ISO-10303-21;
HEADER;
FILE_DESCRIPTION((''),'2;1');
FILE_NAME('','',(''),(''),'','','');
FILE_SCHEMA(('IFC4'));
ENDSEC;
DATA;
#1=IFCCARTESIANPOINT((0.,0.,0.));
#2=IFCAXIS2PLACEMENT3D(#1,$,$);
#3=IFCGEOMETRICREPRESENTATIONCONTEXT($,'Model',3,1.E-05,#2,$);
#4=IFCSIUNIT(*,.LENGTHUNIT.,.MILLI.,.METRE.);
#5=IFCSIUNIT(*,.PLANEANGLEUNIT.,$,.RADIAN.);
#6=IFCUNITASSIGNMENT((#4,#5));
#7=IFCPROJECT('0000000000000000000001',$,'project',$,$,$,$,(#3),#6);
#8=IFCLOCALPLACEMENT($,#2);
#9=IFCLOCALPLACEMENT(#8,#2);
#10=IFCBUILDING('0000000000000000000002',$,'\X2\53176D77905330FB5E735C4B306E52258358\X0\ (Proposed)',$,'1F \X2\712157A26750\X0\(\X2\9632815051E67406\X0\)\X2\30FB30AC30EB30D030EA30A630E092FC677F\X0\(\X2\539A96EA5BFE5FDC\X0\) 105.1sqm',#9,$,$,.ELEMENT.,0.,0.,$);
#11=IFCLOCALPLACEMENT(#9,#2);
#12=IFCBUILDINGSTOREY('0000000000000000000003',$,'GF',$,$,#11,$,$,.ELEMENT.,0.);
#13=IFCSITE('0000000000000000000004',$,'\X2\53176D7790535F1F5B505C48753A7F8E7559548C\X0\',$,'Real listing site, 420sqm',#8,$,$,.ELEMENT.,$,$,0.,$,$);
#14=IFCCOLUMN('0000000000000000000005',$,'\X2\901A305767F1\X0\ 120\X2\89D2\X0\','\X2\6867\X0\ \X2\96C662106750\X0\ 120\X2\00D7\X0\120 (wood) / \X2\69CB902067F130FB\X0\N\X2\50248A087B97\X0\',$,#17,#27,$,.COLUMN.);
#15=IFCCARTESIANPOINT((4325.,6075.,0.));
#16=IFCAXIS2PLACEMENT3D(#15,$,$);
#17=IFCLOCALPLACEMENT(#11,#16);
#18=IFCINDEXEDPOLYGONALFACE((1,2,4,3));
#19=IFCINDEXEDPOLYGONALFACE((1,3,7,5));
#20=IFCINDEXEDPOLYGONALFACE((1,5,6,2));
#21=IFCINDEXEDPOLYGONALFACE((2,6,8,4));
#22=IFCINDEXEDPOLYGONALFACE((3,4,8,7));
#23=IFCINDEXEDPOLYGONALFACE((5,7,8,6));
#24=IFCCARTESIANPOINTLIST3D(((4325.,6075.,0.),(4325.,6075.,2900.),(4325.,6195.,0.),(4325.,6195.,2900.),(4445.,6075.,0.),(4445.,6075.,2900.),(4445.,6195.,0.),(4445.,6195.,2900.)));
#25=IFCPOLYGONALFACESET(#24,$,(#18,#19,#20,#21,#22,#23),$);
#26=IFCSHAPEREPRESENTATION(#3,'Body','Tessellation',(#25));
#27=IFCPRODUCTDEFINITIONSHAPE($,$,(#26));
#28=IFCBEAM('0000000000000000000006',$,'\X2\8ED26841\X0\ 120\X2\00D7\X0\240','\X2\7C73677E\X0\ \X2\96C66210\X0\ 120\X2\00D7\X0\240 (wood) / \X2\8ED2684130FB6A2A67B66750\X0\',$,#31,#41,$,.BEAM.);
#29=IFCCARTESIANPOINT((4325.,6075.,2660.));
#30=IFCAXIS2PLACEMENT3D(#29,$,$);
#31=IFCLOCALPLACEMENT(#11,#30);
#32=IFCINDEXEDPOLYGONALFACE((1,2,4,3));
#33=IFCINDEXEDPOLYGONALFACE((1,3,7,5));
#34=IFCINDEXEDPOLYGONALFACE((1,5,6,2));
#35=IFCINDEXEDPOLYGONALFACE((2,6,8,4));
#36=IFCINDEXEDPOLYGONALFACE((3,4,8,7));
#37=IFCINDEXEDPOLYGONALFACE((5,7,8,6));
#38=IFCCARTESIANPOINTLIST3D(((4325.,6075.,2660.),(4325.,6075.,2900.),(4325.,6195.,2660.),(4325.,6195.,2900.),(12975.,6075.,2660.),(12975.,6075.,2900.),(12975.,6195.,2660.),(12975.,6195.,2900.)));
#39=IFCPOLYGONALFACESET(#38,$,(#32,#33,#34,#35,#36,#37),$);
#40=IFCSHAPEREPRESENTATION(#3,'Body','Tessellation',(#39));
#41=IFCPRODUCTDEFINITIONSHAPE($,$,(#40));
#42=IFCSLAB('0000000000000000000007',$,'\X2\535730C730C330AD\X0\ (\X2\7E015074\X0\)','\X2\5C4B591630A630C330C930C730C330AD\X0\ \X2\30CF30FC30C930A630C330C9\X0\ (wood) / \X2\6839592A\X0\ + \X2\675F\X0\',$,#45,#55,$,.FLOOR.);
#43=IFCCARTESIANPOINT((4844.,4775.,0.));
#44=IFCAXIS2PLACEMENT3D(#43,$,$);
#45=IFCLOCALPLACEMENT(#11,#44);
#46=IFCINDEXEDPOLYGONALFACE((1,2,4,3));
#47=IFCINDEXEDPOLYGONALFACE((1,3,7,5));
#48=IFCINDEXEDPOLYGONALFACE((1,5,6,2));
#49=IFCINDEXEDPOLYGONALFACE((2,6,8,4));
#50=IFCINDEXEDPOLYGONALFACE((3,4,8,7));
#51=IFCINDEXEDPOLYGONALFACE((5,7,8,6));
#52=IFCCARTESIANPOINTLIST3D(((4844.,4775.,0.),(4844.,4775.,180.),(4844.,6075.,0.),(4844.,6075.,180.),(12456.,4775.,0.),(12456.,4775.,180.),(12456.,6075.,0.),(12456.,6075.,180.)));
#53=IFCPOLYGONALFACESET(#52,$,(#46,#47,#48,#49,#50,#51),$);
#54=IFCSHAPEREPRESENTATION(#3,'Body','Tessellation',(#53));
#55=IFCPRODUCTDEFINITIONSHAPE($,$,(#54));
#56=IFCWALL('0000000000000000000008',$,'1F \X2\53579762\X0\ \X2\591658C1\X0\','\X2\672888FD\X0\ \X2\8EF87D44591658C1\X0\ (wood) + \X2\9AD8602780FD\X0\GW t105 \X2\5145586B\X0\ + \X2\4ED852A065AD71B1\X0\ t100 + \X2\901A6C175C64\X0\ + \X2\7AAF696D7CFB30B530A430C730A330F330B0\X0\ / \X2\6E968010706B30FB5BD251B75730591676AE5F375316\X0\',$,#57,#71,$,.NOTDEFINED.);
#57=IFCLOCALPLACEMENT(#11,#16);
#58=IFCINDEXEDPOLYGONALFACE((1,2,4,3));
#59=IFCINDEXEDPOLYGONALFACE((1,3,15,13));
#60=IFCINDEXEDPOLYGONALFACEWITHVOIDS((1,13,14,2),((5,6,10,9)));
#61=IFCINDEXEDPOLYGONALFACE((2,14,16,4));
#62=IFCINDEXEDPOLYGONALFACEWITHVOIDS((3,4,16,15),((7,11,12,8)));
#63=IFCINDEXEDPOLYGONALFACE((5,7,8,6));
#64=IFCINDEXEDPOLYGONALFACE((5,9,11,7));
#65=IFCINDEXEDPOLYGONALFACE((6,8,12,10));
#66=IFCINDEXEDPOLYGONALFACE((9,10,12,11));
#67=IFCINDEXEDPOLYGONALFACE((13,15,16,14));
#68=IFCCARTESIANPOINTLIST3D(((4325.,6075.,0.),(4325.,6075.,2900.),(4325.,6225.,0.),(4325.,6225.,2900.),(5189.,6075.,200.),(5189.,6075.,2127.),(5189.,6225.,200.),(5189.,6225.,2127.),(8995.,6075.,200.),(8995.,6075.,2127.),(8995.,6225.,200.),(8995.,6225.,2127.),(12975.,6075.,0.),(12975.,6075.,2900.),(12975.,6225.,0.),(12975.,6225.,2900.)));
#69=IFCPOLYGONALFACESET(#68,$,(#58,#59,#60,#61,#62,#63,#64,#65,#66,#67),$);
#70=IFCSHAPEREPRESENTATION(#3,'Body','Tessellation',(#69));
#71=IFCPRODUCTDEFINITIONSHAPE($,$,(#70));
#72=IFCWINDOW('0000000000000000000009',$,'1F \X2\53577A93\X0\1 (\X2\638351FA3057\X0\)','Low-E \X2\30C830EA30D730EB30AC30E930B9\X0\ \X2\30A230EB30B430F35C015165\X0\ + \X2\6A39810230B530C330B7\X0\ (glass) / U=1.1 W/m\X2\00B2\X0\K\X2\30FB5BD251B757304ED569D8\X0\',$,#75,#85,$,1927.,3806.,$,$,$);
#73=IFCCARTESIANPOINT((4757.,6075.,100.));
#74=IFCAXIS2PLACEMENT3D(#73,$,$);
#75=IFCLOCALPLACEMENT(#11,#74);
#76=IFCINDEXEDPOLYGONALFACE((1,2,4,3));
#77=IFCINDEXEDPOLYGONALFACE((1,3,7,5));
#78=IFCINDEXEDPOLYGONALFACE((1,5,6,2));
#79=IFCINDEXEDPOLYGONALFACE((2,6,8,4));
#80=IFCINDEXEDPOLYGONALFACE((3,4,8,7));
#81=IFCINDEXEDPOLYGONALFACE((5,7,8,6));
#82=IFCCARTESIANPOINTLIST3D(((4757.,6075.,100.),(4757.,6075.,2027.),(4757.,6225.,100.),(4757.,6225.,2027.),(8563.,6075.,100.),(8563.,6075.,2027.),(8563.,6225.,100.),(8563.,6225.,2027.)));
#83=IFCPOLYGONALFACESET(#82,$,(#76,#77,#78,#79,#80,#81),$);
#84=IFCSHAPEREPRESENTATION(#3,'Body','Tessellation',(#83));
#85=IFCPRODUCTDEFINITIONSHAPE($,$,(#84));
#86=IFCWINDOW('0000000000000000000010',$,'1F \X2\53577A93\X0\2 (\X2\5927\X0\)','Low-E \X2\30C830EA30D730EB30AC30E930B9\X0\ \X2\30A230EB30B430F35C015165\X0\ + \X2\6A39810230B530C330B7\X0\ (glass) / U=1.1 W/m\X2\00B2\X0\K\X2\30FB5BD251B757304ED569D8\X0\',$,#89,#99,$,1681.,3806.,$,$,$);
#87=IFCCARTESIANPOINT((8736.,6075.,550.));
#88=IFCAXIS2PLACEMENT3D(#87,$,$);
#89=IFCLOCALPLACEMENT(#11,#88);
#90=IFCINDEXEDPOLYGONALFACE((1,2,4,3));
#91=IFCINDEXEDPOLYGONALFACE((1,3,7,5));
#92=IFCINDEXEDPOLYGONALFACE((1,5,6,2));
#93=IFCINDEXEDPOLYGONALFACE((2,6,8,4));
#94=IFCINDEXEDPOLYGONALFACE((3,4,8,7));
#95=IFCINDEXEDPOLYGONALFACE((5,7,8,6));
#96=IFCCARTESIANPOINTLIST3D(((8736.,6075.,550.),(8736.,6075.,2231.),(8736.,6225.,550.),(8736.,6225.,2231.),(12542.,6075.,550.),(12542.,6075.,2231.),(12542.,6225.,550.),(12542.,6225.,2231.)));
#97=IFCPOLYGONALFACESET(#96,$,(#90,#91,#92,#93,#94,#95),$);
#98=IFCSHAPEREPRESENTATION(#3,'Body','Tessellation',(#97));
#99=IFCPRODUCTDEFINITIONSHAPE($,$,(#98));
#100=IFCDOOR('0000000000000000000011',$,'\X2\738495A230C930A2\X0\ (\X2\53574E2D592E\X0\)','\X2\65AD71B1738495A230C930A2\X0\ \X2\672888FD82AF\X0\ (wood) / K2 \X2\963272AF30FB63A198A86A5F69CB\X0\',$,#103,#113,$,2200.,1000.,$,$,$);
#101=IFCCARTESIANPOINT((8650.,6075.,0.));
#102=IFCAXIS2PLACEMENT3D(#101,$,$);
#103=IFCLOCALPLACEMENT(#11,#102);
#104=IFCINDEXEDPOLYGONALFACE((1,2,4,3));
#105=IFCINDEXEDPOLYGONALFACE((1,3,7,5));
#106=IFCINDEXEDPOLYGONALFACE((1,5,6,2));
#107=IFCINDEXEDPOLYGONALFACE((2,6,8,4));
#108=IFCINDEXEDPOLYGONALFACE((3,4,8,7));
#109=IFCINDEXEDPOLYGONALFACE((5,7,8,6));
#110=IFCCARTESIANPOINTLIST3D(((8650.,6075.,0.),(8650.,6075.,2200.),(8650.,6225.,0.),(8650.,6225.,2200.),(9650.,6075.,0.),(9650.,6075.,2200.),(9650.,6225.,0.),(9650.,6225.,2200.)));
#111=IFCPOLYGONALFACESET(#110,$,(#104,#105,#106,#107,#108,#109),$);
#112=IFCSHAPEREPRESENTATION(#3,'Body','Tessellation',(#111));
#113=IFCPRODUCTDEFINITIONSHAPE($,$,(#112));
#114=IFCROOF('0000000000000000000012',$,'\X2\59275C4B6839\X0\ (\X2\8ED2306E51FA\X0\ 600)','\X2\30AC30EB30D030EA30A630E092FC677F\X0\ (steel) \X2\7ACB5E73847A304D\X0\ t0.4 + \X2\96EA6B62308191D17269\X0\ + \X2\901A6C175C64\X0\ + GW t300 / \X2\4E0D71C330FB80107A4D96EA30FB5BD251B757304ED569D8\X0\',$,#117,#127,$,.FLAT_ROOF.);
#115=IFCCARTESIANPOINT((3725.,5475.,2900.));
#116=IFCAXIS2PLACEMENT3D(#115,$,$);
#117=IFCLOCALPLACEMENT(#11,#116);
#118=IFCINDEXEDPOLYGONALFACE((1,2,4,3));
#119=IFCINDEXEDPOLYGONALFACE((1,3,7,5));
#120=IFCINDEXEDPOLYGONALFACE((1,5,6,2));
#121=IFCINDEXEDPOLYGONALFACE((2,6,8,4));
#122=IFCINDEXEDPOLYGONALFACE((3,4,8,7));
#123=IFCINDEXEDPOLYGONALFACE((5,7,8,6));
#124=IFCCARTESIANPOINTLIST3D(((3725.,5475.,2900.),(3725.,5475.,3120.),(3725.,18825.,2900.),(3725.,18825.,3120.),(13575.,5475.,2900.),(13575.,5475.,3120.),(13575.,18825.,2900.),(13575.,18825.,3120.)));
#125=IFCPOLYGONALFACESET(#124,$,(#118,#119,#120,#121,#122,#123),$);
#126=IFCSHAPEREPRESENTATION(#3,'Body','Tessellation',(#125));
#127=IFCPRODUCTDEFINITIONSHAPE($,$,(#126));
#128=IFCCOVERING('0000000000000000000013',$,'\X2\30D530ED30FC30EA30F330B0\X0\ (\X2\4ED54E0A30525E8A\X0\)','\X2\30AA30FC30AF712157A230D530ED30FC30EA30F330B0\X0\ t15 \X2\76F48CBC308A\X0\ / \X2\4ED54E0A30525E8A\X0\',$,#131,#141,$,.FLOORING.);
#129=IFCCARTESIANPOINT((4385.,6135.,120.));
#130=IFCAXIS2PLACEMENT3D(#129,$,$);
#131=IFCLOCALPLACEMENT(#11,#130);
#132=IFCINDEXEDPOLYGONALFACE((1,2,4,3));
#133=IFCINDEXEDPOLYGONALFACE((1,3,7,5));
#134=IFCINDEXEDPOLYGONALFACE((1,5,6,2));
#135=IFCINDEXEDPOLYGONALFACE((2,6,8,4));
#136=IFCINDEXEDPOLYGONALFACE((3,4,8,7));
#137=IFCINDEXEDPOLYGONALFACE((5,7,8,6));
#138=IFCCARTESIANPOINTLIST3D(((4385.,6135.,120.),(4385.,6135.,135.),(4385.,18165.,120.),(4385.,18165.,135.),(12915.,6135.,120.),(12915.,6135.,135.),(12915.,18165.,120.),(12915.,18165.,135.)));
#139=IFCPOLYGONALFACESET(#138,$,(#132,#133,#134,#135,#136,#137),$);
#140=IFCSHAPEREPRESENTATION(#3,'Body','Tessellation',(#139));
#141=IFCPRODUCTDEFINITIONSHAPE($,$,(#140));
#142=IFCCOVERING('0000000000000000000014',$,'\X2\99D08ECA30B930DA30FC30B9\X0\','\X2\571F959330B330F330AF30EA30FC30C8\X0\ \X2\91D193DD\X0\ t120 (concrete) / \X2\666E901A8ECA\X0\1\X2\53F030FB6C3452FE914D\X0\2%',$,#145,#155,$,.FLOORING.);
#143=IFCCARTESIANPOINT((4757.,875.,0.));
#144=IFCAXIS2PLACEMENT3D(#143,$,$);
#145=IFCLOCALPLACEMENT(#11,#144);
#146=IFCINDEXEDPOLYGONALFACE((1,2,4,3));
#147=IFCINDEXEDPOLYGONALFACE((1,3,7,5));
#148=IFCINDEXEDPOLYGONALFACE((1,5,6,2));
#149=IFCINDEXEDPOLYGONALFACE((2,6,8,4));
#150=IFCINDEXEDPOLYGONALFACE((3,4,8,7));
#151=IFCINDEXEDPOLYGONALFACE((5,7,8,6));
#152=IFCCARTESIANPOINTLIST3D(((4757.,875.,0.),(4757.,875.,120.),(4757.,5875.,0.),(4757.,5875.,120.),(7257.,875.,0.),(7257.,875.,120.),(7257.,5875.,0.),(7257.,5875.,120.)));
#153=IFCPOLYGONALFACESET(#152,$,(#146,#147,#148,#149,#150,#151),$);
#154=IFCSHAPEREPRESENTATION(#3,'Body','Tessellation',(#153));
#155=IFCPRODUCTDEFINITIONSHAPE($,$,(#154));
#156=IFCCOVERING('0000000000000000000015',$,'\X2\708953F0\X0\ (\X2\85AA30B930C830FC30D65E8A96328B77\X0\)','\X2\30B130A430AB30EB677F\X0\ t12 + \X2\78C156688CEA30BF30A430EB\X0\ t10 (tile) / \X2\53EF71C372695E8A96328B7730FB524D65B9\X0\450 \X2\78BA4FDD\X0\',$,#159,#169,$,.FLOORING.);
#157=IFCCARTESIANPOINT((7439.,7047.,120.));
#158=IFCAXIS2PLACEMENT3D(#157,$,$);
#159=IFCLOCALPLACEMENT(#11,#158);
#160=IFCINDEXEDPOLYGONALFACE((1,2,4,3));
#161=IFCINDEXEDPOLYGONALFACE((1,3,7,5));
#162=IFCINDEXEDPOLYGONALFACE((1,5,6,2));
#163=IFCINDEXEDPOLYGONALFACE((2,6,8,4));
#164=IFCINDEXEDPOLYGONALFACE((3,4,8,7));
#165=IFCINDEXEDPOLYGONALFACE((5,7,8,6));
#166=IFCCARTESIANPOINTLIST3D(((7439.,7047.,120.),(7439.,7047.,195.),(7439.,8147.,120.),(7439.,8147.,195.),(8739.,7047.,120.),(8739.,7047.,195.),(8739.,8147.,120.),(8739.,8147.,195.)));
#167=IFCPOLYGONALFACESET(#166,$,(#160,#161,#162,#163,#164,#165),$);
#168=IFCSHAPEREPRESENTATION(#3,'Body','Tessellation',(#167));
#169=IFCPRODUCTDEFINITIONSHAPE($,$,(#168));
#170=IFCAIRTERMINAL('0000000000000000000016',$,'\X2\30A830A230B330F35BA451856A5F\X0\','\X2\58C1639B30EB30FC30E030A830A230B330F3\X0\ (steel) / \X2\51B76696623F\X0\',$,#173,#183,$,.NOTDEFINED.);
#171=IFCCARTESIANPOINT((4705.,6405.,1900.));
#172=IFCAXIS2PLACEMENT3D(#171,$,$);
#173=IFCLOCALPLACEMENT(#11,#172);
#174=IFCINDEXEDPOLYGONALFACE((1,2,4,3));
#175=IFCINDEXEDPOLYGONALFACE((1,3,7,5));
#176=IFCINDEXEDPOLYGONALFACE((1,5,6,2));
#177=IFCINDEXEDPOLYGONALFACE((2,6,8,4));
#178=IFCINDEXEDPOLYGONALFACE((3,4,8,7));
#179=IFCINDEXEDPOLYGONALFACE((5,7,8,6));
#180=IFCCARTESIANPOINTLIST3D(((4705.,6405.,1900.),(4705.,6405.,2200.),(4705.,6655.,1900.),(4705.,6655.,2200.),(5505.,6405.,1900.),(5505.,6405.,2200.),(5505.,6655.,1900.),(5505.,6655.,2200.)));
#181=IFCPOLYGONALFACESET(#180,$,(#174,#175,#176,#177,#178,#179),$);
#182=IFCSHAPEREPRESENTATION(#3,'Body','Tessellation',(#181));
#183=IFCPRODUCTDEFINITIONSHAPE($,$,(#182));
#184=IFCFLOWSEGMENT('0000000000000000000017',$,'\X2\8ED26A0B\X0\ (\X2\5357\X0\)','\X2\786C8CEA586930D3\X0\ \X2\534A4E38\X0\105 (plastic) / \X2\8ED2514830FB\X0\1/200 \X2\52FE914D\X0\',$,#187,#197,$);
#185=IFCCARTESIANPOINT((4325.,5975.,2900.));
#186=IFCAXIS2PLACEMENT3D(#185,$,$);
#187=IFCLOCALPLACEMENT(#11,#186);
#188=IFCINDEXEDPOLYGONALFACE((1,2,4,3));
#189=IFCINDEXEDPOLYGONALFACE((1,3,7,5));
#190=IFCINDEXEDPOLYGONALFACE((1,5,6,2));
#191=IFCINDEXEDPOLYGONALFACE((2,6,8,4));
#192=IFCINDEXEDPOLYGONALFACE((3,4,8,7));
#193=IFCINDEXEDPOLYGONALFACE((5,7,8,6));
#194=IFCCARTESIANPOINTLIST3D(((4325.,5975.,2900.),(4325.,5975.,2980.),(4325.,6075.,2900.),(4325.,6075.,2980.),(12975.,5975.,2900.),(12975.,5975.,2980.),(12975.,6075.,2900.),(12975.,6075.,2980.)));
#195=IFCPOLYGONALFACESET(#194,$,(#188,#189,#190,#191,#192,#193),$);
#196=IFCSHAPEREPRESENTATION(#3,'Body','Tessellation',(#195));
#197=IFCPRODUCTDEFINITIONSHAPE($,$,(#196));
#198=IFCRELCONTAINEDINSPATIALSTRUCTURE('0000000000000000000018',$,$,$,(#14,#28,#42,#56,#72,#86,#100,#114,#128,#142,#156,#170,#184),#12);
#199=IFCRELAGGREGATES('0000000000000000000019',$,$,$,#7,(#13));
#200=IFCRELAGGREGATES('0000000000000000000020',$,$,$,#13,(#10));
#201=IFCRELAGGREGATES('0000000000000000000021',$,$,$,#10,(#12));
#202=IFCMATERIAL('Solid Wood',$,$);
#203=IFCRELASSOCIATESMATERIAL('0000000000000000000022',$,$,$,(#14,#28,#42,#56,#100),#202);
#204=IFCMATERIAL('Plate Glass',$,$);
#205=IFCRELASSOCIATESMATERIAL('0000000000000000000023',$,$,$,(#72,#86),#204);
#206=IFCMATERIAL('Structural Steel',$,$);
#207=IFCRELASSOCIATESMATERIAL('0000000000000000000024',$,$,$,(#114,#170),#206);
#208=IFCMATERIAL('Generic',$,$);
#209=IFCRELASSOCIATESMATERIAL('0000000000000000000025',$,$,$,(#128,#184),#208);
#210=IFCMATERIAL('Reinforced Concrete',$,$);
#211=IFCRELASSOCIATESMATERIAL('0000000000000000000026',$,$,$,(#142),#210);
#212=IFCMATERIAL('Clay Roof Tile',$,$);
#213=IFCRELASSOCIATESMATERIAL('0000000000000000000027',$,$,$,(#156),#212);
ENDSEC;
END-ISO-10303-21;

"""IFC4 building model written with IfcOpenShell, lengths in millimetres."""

from ifc_helpers import new_model, si_unit, frame, frame_2d, origin, place, context, project, spatial, rectangle, extrude, material, element, fill, save


model = new_model("IFC4")

# Units and contexts
model_context = context("Model", 3, precision=1e-05, world=origin())
ifc_project = project(units=[si_unit("LENGTHUNIT", "METRE", prefix="MILLI"), si_unit("PLANEANGLEUNIT", "RADIAN")], contexts=[model_context])

# Site, building, storey
site_placement = place(None, origin())
site = spatial("IfcSite", under=ifc_project, at=site_placement, Name="北海道弟子屈町美留和", ObjectType="Real listing site, 420sqm", CompositionType="ELEMENT", RefElevation=0.0)
building_placement = place(site_placement, origin())
building = spatial("IfcBuilding", under=site, at=building_placement, Name="北海道・平屋の別荘 (Proposed)", ObjectType="1F 無垢材(防腐処理)・ガルバリウム鋼板(厚雪対応) 105.1sqm", CompositionType="ELEMENT", ElevationOfRefHeight=0.0, ElevationOfTerrain=0.0)
storey_placement = place(building_placement, origin())
storey = spatial("IfcBuildingStorey", under=building, at=storey_placement, Name="GF", CompositionType="ELEMENT", Elevation=0.0)

# Column
ifc_material_1 = material(Name="Solid Wood")
column_1_placement = place(storey_placement, frame((4325.0, 6075.0, 0.0)))
element("IfcColumn", 1, at=column_1_placement, inside=storey, material=ifc_material_1, Name="通し柱 120角", Description="桧 集成材 120×120 (wood) / 構造柱・N値計算", PredefinedType="COLUMN", context=model_context, shape_type="SweptSolid", body=[
    extrude(rectangle(XDim=120.0, YDim=120.0, at=frame_2d((60.0, 60.0))), frame((4325.0, 6075.0, 0.0)), (0.0, 0.0, 1.0), 2900.0),
])

# Beam
beam_1_placement = place(storey_placement, frame((4325.0, 6075.0, 2660.0)))
element("IfcBeam", 2, at=beam_1_placement, inside=storey, material=ifc_material_1, Name="軒桁 120×240", Description="米松 集成 120×240 (wood) / 軒桁・横架材", PredefinedType="BEAM", context=model_context, shape_type="SweptSolid", body=[
    extrude(rectangle(XDim=8650.0, YDim=120.0, at=frame_2d((4325.0, 60.0))), frame((4325.0, 6075.0, 2660.0)), (0.0, 0.0, 1.0), 240.0),
])

# Slab
ifc_material_2 = material(Name="Reinforced Concrete")
slab_1_placement = place(storey_placement, frame((4844.0, 4775.0, 0.0)))
element("IfcSlab", 3, at=slab_1_placement, inside=storey, material=ifc_material_1, Name="南デッキ (縁側)", Description="屋外ウッドデッキ ハードウッド (wood) / 根太 + 束", PredefinedType="FLOOR", context=model_context, shape_type="SweptSolid", body=[
    extrude(rectangle(XDim=7612.0, YDim=1300.0, at=frame_2d((3806.0, 650.0))), frame((4844.0, 4775.0, 0.0)), (0.0, 0.0, 1.0), 180.0),
])

# Wall, openings, windows, door
wall_1_placement = place(storey_placement, frame((4325.0, 6075.0, 0.0)))
wall_1 = element("IfcWall", 4, at=wall_1_placement, inside=storey, material=ifc_material_1, Name="1F 南面 外壁", Description="木製 軸組外壁 (wood) + 高性能GW t105 充填 + 付加断熱 t100 + 通気層 + 窯業系サイディング / 準耐火・寒冷地外皮強化", PredefinedType="NOTDEFINED", context=model_context, shape_type="SweptSolid", body=[
    extrude(rectangle(XDim=8650.0, YDim=150.0, at=frame_2d((4325.0, 75.0))), frame((4325.0, 6075.0, 0.0)), (0.0, 0.0, 1.0), 2900.0),
])
opening_1_placement = place(storey_placement, frame((4757.0, 6075.0, 100.0)))
opening_1 = element("IfcOpeningElement", 5, at=opening_1_placement, cuts=wall_1, PredefinedType="NOTDEFINED", context=model_context, shape_type="SweptSolid", body=[
    extrude(rectangle(XDim=3806.0, YDim=150.0, at=frame_2d((1903.0, 75.0))), frame((4757.0, 6075.0, 100.0)), (0.0, 0.0, 1.0), 1927.0),
])
opening_2_placement = place(storey_placement, frame((8736.0, 6075.0, 550.0)))
opening_2 = element("IfcOpeningElement", 6, at=opening_2_placement, cuts=wall_1, PredefinedType="NOTDEFINED", context=model_context, shape_type="SweptSolid", body=[
    extrude(rectangle(XDim=3806.0, YDim=150.0, at=frame_2d((1903.0, 75.0))), frame((8736.0, 6075.0, 550.0)), (0.0, 0.0, 1.0), 1681.0),
])
opening_3_placement = place(storey_placement, frame((8650.0, 6075.0, 0.0)))
opening_3 = element("IfcOpeningElement", 7, at=opening_3_placement, cuts=wall_1, PredefinedType="NOTDEFINED", context=model_context, shape_type="SweptSolid", body=[
    extrude(rectangle(XDim=1000.0, YDim=150.0, at=frame_2d((500.0, 75.0))), frame((8650.0, 6075.0, 0.0)), (0.0, 0.0, 1.0), 2200.0),
])
ifc_material_3 = material(Name="Plate Glass")
window_1_placement = place(storey_placement, frame((4757.0, 6075.0, 100.0)))
window_1 = element("IfcWindow", 8, at=window_1_placement, inside=storey, material=ifc_material_3, Name="1F 南窓1 (掃出し)", Description="Low-E トリプルガラス アルゴン封入 + 樹脂サッシ (glass) / U=1.1 W/m²K・寒冷地仕様", OverallHeight=1927.0, OverallWidth=3806.0, context=model_context, shape_type="SweptSolid", body=[
    extrude(rectangle(XDim=3806.0, YDim=150.0, at=frame_2d((1903.0, 75.0))), frame((4757.0, 6075.0, 100.0)), (0.0, 0.0, 1.0), 1927.0),
])
fill(opening_1, window_1)
window_2_placement = place(storey_placement, frame((8736.0, 6075.0, 550.0)))
window_2 = element("IfcWindow", 9, at=window_2_placement, inside=storey, material=ifc_material_3, Name="1F 南窓2 (大)", Description="Low-E トリプルガラス アルゴン封入 + 樹脂サッシ (glass) / U=1.1 W/m²K・寒冷地仕様", OverallHeight=1681.0, OverallWidth=3806.0, context=model_context, shape_type="SweptSolid", body=[
    extrude(rectangle(XDim=3806.0, YDim=150.0, at=frame_2d((1903.0, 75.0))), frame((8736.0, 6075.0, 550.0)), (0.0, 0.0, 1.0), 1681.0),
])
fill(opening_2, window_2)
door_placement = place(storey_placement, frame((8650.0, 6075.0, 0.0)))
door = element("IfcDoor", 10, at=door_placement, inside=storey, material=ifc_material_1, Name="玄関ドア (南中央)", Description="断熱玄関ドア 木製芯 (wood) / K2 防犯・採風機構", OverallHeight=2200.0, OverallWidth=1000.0, context=model_context, shape_type="SweptSolid", body=[
    extrude(rectangle(XDim=1000.0, YDim=150.0, at=frame_2d((500.0, 75.0))), frame((8650.0, 6075.0, 0.0)), (0.0, 0.0, 1.0), 2200.0),
])
fill(opening_3, door)

# Roof
ifc_material_4 = material(Name="Structural Steel")
roof_placement = place(storey_placement, frame((3725.0, 5475.0, 2900.0)))
element("IfcRoof", 11, at=roof_placement, inside=storey, material=ifc_material_4, Name="大屋根 (軒の出 600)", Description="ガルバリウム鋼板 (steel) 立平葺き t0.4 + 雪止め金物 + 通気層 + GW t300 / 不燃・耐積雪・寒冷地仕様", PredefinedType="FLAT_ROOF", context=model_context, shape_type="SweptSolid", body=[
    extrude(rectangle(XDim=9850.0, YDim=13350.0, at=frame_2d((4925.0, 6675.0))), frame((3725.0, 5475.0, 2900.0)), (0.0, 0.0, 1.0), 220.0),
])

# Coverings
ifc_material_5 = material(Name="Generic")
covering_1_placement = place(storey_placement, frame((4385.0, 6135.0, 120.0)))
element("IfcCovering", 12, at=covering_1_placement, inside=storey, material=ifc_material_5, Name="フローリング (仕上げ床)", Description="オーク無垢フローリング t15 直貼り / 仕上げ床", PredefinedType="FLOORING", context=model_context, shape_type="SweptSolid", body=[
    extrude(rectangle(XDim=8530.0, YDim=12030.0, at=frame_2d((4265.0, 6015.0))), frame((4385.0, 6135.0, 120.0)), (0.0, 0.0, 1.0), 15.0),
])
covering_2_placement = place(storey_placement, frame((4757.0, 875.0, 0.0)))
element("IfcCovering", 13, at=covering_2_placement, inside=storey, material=ifc_material_2, Name="駐車スペース", Description="土間コンクリート 金鏝 t120 (concrete) / 普通車1台・水勾配2%", PredefinedType="FLOORING", context=model_context, shape_type="SweptSolid", body=[
    extrude(rectangle(XDim=2500.0, YDim=5000.0, at=frame_2d((1250.0, 2500.0))), frame((4757.0, 875.0, 0.0)), (0.0, 0.0, 1.0), 120.0),
])
ifc_material_6 = material(Name="Clay Roof Tile")
covering_3_placement = place(storey_placement, frame((7439.0, 7047.0, 120.0)))
element("IfcCovering", 14, at=covering_3_placement, inside=storey, material=ifc_material_6, Name="炉台 (薪ストーブ床防護)", Description="ケイカル板 t12 + 磁器質タイル t10 (tile) / 可燃物床防護・前方450 確保", PredefinedType="FLOORING", context=model_context, shape_type="SweptSolid", body=[
    extrude(rectangle(XDim=1300.0, YDim=1100.0, at=frame_2d((650.0, 550.0))), frame((7439.0, 7047.0, 120.0)), (0.0, 0.0, 1.0), 75.0),
])

# Air terminal
air_terminal_placement = place(storey_placement, frame((4705.0, 6405.0, 1900.0)))
element("IfcAirTerminal", 15, at=air_terminal_placement, inside=storey, material=ifc_material_4, Name="エアコン室内機", Description="壁掛ルームエアコン (steel) / 冷暖房", PredefinedType="NOTDEFINED", context=model_context, shape_type="SweptSolid", body=[
    extrude(rectangle(XDim=800.0, YDim=250.0, at=frame_2d((400.0, 125.0))), frame((4705.0, 6405.0, 1900.0)), (0.0, 0.0, 1.0), 300.0),
])

# Flow segment
flow_segment_1_placement = place(storey_placement, frame((4325.0, 5975.0, 2900.0)))
element("IfcFlowSegment", 16, at=flow_segment_1_placement, inside=storey, material=ifc_material_5, Name="軒樋 (南)", Description="硬質塩ビ 半丸105 (plastic) / 軒先・1/200 勾配", context=model_context, shape_type="SweptSolid", body=[
    extrude(rectangle(XDim=8650.0, YDim=100.0, at=frame_2d((4325.0, 50.0))), frame((4325.0, 5975.0, 2900.0)), (0.0, 0.0, 1.0), 80.0),
])

save(model, "model.ifc")
